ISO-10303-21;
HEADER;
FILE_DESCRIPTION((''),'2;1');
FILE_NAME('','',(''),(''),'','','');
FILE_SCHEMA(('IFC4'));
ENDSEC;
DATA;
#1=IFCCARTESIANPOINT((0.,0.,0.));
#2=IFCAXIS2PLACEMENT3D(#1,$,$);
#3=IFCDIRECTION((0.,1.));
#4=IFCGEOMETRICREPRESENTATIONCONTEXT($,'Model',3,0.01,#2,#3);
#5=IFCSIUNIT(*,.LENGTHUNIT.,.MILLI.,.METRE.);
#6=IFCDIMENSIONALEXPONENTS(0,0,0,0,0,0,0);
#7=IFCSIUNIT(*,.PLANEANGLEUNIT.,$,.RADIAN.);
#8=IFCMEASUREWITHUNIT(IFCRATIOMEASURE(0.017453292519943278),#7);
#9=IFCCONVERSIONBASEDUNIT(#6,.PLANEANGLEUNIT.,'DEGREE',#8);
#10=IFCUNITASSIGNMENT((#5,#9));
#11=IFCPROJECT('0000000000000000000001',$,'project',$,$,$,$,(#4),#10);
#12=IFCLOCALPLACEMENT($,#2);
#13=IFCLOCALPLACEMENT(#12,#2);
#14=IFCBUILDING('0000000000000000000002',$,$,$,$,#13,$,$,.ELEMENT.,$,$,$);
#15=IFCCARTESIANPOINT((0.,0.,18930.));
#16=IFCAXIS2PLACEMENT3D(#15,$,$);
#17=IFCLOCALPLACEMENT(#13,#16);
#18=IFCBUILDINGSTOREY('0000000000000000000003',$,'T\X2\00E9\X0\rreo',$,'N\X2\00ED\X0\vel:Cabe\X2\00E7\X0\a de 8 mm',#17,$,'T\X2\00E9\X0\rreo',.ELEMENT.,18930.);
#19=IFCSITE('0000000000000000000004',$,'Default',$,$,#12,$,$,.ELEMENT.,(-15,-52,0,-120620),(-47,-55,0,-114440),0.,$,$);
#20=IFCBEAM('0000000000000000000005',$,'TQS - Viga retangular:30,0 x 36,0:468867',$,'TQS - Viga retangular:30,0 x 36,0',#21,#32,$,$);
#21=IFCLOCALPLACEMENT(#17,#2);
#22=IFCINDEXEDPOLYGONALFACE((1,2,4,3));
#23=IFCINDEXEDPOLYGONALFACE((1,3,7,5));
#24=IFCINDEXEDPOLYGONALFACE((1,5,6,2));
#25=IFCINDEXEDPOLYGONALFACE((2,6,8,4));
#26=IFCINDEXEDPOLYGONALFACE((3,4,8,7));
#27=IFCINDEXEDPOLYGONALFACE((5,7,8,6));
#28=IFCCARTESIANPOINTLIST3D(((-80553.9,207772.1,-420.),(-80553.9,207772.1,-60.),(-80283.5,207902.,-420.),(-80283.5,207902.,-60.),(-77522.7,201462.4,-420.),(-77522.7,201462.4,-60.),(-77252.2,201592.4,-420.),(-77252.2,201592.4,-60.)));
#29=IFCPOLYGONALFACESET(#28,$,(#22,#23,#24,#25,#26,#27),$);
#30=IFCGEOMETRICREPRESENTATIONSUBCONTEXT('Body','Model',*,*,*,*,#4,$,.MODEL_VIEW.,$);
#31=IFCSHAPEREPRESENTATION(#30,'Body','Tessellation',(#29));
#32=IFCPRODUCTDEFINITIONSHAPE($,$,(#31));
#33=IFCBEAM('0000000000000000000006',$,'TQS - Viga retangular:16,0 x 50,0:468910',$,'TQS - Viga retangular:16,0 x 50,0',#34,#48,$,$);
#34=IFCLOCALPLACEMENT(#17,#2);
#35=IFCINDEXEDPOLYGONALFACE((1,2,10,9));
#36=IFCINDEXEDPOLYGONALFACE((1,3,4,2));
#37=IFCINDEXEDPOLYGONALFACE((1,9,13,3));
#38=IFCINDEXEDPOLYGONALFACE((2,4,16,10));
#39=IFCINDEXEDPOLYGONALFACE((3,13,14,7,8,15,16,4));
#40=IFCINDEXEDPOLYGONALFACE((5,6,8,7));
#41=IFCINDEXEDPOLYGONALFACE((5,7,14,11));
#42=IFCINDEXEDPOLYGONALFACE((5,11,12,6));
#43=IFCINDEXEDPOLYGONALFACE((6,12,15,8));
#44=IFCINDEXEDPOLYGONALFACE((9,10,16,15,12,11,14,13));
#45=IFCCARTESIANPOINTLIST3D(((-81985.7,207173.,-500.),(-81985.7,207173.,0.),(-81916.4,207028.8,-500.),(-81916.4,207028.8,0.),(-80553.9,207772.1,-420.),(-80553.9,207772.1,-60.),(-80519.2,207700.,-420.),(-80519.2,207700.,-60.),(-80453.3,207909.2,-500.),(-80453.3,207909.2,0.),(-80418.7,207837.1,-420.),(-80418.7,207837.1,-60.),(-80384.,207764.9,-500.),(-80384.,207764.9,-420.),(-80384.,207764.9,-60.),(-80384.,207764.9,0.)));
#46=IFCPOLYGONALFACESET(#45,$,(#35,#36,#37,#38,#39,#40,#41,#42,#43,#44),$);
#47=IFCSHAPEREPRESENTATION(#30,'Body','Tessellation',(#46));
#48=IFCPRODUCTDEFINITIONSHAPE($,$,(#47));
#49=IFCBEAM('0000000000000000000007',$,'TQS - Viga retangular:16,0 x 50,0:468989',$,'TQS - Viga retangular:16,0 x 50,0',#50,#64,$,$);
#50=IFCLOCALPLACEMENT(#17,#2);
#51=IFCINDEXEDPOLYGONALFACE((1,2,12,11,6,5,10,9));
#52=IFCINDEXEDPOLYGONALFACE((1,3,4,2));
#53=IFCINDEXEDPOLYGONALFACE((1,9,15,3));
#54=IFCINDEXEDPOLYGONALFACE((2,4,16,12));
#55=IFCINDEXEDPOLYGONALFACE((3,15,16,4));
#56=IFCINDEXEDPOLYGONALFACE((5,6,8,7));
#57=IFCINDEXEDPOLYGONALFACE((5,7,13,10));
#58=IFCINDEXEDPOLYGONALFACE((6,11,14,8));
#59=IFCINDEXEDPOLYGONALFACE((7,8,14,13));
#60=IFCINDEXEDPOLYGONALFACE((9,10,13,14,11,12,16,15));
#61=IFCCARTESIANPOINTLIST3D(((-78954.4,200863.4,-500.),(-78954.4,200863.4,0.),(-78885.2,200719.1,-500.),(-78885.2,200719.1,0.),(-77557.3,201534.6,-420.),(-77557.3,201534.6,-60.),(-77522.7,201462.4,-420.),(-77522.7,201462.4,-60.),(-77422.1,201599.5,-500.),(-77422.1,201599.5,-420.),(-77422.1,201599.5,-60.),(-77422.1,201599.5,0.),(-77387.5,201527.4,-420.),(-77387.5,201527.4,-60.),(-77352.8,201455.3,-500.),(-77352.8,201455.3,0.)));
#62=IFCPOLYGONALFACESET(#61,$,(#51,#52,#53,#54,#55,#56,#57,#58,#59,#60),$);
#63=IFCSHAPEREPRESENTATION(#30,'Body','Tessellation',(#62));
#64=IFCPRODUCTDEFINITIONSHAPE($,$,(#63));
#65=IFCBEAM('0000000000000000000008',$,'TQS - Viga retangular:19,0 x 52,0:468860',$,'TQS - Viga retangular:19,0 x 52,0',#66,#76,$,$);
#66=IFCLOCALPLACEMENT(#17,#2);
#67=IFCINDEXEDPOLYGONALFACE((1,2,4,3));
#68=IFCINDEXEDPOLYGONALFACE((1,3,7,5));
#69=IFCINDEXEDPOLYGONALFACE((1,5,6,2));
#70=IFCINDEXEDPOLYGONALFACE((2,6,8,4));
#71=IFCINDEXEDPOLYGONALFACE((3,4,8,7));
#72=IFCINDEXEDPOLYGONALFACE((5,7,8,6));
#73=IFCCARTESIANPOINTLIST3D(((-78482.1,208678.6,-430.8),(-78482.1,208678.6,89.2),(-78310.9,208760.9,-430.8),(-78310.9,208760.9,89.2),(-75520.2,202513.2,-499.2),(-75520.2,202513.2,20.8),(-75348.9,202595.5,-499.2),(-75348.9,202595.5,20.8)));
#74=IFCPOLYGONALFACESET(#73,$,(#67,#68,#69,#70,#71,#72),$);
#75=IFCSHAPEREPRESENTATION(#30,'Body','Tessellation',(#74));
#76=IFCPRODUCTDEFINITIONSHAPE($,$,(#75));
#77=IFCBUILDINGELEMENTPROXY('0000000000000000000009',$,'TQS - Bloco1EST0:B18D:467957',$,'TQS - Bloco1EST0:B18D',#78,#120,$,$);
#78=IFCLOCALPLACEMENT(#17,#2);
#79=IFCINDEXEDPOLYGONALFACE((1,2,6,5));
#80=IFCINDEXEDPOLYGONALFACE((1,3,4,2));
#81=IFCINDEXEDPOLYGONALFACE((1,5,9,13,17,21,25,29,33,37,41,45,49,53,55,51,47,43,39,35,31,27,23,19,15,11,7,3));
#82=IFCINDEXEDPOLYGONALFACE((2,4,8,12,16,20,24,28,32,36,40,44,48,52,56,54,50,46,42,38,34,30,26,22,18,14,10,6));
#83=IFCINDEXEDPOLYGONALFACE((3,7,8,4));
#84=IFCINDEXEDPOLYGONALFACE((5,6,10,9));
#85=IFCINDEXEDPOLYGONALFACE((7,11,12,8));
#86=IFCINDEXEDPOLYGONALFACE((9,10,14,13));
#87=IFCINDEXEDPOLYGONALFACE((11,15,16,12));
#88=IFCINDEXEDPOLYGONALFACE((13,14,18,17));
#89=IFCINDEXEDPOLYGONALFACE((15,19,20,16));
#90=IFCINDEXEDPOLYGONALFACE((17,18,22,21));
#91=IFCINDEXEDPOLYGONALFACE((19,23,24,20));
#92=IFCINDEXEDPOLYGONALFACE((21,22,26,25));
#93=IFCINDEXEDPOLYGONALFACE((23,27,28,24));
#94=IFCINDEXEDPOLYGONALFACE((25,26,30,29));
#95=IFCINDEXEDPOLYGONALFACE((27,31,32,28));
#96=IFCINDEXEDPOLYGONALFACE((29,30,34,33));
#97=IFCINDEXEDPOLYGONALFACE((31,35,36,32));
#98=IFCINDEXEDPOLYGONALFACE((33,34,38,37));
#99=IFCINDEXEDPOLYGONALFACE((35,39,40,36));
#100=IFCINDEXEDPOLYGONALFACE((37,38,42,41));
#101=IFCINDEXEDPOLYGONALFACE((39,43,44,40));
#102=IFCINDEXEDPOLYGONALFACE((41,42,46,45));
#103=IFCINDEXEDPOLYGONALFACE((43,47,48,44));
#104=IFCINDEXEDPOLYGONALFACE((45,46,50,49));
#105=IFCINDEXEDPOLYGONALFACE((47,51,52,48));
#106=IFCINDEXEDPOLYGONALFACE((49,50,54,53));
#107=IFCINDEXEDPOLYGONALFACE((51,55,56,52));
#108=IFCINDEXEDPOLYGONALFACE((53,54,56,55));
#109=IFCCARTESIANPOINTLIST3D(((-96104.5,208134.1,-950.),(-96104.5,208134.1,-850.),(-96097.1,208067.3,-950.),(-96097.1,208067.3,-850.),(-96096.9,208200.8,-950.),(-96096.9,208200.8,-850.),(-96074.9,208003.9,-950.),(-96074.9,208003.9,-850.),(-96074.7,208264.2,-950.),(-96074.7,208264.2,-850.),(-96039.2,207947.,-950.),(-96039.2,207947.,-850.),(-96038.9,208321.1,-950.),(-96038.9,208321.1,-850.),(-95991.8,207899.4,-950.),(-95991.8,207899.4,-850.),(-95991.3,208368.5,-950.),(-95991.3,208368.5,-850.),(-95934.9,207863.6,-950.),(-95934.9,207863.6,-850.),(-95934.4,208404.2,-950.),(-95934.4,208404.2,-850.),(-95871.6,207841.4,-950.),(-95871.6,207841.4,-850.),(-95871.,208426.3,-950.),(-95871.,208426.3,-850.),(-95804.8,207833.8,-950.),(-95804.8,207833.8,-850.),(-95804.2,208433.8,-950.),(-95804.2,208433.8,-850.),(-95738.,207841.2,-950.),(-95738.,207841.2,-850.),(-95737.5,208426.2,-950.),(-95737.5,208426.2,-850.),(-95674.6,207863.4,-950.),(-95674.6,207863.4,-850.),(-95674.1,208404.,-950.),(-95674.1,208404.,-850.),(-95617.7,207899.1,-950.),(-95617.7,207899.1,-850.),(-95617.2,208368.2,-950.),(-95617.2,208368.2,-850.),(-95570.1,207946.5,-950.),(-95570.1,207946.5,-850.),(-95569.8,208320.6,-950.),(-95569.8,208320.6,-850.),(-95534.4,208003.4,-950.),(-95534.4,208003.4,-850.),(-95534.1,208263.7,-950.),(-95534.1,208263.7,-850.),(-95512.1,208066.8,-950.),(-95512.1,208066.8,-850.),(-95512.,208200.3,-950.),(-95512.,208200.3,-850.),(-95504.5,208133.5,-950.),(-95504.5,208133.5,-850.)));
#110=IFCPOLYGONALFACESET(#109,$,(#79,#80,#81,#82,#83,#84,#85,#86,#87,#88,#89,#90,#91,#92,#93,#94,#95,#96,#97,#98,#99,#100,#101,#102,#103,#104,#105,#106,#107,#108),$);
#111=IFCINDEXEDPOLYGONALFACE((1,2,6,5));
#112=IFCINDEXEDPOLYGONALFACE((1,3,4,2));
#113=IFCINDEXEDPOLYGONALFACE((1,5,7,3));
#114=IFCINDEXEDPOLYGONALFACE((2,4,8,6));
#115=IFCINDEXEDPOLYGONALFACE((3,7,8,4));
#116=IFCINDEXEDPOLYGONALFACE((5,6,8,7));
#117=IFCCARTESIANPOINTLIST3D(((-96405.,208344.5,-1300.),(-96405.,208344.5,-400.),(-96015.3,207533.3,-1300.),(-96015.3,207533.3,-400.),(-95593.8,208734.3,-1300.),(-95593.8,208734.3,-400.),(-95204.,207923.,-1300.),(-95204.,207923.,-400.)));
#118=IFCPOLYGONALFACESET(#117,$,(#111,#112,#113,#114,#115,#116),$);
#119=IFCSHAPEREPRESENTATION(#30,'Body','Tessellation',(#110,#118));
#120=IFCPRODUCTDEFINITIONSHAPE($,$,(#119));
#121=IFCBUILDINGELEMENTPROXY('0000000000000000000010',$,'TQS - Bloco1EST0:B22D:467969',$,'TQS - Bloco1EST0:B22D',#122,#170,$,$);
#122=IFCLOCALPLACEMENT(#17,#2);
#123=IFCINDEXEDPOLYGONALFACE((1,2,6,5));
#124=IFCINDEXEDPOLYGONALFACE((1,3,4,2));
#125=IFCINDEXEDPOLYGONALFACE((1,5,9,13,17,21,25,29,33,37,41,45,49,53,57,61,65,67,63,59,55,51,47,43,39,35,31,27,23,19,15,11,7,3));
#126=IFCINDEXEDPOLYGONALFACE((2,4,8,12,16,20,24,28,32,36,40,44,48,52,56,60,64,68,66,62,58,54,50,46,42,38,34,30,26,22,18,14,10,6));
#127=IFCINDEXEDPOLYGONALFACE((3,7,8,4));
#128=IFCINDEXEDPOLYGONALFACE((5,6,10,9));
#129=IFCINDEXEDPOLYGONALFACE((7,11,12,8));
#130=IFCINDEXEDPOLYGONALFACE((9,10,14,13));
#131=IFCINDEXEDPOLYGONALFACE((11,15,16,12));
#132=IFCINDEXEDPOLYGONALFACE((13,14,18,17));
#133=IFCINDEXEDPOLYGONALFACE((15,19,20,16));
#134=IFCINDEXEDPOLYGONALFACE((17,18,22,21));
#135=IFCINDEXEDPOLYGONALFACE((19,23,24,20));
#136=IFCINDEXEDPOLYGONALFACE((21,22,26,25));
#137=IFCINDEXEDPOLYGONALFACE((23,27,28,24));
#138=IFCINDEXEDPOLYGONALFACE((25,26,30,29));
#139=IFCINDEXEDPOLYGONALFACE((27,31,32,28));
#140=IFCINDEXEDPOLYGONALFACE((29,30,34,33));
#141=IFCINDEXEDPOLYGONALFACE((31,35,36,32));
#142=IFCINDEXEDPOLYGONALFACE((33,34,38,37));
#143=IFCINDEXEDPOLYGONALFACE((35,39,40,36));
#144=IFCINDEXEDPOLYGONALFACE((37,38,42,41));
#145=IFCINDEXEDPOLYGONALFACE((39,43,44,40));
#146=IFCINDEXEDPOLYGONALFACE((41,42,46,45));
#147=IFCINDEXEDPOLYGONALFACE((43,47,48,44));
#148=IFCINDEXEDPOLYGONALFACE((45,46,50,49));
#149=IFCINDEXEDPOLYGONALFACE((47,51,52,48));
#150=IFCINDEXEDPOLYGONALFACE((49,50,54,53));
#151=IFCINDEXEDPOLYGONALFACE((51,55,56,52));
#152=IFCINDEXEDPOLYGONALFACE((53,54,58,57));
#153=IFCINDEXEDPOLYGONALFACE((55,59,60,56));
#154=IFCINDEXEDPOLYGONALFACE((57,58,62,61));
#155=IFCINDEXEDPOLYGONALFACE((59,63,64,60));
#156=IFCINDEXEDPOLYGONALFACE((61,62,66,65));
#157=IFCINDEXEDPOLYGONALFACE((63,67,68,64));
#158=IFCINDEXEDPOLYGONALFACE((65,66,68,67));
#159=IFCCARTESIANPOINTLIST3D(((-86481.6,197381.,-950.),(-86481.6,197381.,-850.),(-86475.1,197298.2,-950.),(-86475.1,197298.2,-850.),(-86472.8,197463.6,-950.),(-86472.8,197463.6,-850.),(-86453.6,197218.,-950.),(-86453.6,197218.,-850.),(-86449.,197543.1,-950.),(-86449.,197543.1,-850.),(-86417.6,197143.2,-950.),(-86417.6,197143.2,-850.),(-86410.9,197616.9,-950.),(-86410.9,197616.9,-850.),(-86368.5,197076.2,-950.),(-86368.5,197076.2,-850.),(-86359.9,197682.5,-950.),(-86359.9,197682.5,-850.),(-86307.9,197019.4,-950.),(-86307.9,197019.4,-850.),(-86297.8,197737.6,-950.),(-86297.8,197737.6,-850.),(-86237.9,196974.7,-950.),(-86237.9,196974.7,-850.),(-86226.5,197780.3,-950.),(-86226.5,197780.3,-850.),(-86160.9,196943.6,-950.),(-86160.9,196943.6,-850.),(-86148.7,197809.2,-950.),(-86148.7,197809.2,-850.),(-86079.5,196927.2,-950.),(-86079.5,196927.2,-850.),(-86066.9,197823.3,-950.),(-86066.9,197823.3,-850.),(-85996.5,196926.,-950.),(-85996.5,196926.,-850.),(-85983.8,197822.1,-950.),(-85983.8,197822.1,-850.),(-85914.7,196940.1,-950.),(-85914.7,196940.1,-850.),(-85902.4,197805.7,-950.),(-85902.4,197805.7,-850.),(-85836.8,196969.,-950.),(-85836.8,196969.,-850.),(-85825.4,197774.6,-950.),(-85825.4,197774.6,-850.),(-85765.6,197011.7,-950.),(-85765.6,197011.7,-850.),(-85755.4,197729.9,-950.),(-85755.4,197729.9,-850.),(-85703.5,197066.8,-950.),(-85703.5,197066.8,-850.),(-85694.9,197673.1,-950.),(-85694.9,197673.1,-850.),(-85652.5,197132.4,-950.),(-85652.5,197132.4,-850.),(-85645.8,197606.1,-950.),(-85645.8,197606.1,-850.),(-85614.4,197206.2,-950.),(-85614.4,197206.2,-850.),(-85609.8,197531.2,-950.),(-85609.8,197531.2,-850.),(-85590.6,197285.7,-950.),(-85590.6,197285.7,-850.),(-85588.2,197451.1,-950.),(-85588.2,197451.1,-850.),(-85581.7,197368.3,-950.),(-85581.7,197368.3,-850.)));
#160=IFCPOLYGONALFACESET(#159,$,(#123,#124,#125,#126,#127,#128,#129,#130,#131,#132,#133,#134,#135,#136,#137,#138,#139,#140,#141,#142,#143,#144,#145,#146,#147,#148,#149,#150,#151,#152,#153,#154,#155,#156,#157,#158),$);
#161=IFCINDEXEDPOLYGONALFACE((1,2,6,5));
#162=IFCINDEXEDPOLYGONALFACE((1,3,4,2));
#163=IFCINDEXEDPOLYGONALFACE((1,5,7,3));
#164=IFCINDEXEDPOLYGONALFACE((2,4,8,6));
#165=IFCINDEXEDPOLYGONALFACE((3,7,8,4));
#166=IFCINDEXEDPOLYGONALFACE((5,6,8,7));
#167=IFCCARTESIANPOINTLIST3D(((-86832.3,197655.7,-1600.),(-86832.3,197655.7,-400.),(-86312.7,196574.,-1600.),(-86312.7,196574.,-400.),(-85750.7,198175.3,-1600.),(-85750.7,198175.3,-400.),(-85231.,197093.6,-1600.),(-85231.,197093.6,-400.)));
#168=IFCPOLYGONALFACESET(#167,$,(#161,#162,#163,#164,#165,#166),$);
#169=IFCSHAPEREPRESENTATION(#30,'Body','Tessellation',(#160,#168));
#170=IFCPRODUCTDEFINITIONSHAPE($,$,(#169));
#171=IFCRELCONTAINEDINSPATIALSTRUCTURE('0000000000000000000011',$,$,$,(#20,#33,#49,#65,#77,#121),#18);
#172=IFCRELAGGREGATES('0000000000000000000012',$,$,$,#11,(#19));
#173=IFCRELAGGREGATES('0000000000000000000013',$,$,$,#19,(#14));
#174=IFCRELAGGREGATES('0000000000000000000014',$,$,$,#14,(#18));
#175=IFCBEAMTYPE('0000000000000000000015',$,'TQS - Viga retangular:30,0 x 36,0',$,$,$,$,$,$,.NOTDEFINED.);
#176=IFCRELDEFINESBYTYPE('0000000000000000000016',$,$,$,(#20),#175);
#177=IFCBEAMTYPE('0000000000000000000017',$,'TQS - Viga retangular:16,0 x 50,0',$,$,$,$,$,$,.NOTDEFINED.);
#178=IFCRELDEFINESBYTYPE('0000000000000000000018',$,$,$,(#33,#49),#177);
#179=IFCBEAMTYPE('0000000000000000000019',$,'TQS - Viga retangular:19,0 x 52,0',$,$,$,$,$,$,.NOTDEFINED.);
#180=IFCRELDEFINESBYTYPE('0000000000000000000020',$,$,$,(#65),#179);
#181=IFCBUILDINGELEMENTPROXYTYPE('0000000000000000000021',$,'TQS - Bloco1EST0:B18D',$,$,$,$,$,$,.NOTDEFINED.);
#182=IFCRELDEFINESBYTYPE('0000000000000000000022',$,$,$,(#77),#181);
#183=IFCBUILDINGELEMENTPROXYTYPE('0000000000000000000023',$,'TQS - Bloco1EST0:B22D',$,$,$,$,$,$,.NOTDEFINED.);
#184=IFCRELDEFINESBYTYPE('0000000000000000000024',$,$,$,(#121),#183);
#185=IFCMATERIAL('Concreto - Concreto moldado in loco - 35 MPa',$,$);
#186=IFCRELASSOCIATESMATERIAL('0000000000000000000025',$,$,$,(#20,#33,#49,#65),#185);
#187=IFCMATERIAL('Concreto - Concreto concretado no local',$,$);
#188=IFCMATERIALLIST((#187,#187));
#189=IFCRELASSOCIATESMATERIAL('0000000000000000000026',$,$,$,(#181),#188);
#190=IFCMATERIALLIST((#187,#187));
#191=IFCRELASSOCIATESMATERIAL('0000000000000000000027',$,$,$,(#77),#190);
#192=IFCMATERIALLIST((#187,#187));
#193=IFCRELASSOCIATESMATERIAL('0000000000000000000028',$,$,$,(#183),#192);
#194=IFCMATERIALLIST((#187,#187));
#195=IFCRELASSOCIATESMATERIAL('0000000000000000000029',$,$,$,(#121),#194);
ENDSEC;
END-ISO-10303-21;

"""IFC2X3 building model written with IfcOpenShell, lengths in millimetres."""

from ifc_helpers import new_model, entity, si_unit, converted_unit, direction, frame, frame_2d, origin, origin_2d_with_axis, place, context, subcontext, project, spatial, polyline, rectangle, circle, extrude, boolean, clip, halfspace, bounded_halfspace, source, transform, mapped, material, material_list, type_object, type_shapes, element, save


model = new_model("IFC2X3")

# Units and contexts
model_context = context("Model", 3, precision=0.01, world=origin(), true_north=direction((0.0, 1.0)))
body_context = subcontext(model_context, "Body", "Model", "MODEL_VIEW")
ifc_project = project(units=[si_unit("LENGTHUNIT", "METRE", prefix="MILLI"), converted_unit("PLANEANGLEUNIT", "DEGREE", entity("IfcRatioMeasure", 0.017453292519943278), si_unit("PLANEANGLEUNIT", "RADIAN"), dimensions=[0, 0, 0, 0, 0, 0, 0])], contexts=[model_context])

# Site, building, storey
site_placement = place(None, origin())
site = spatial("IfcSite", under=ifc_project, at=site_placement, Name="Default", CompositionType="ELEMENT", RefLatitude=(-15, -52, 0, -120620), RefLongitude=(-47, -55, 0, -114440), RefElevation=0.0)
building_placement = place(site_placement, origin())
building = spatial("IfcBuilding", under=site, at=building_placement, CompositionType="ELEMENT")
storey_placement = place(building_placement, frame((0.0, 0.0, 18930.0)))
storey = spatial("IfcBuildingStorey", under=building, at=storey_placement, Name="Térreo", ObjectType="Nível:Cabeça de 8 mm", LongName="Térreo", CompositionType="ELEMENT", Elevation=18930.0)

# Beams
ifc_material_1 = material(Name="Concreto - Concreto moldado in loco - 35 MPa")
beam_type_1 = type_object("IfcBeamType", Name="TQS - Viga retangular:30,0 x 36,0", PredefinedType="NOTDEFINED")
beam_1_placement = place(storey_placement, frame((-77387.5, 201527.4, -60.0), z_axis=(0.0, 0.0, 1.0), x_axis=(-0.43303, 0.90138, 0.0)))
element("IfcBeam", 1, at=beam_1_placement, inside=storey, type_object=beam_type_1, material=ifc_material_1, Name="TQS - Viga retangular:30,0 x 36,0:468867", ObjectType="TQS - Viga retangular:30,0 x 36,0", context=body_context, shape_type="SweptSolid", body=[
    extrude(rectangle(XDim=360.0, YDim=300.0, at=frame_2d((0.0, 0.0), x_axis=(1.0, 0.0))), frame((0.0, 0.0, -180.0), z_axis=(1.0, 0.0, 0.0), x_axis=(0.0, 0.0, -1.0)), (0.0, 0.0, 1.0), 7000.0),
])
beam_type_2 = type_object("IfcBeamType", Name="TQS - Viga retangular:16,0 x 50,0", PredefinedType="NOTDEFINED")
beam_2_placement = place(storey_placement, frame((-80418.7, 207837.1, 0.0), z_axis=(0.0, 0.0, 1.0), x_axis=(-0.90138, -0.43303, 0.0)))
element("IfcBeam", 2, at=beam_2_placement, inside=storey, type_object=beam_type_2, material=ifc_material_1, Name="TQS - Viga retangular:16,0 x 50,0:468910", ObjectType="TQS - Viga retangular:16,0 x 50,0", context=body_context, shape_type="SweptSolid", body=[
    boolean("DIFFERENCE", clip(extrude(rectangle(XDim=500.0, YDim=160.0, at=frame_2d((0.0, 0.0), x_axis=(1.0, 0.0))), frame((0.0, 0.0, -250.0), z_axis=(1.0, 0.0, 0.0), x_axis=(0.0, 0.0, -1.0)), (0.0, 0.0, 1.0), 1700.0), bounded_halfspace(frame((150.0, 0.0, -420.0), z_axis=(-1.0, 0.0, 0.0), x_axis=(0.0, 1.0, 0.0)), False, frame((0.0, 0.0, -250.0), z_axis=(1.0, 0.0, 0.0), x_axis=(0.0, 0.0, -1.0)), polyline([(170.0, 0.0), (-190.0, 0.0), (-190.0, 80.0), (-90.0, 80.0), (170.0, 80.0), (170.0, 0.0)]))), extrude(rectangle(XDim=360.0, YDim=80.0, at=frame_2d((0.0, 0.0), x_axis=(0.0, 1.0))), frame((0.0, 40.0, -240.0), z_axis=(-1.0, 0.0, 0.0), x_axis=(0.0, -1.0, 0.0)), (0.0, 0.0, -1.0), 150.0)),
])
beam_3_placement = place(storey_placement, frame((-77387.5, 201527.4, 0.0), z_axis=(0.0, 0.0, 1.0), x_axis=(-0.90138, -0.43303, 0.0)))
element("IfcBeam", 3, at=beam_3_placement, inside=storey, type_object=beam_type_2, material=ifc_material_1, Name="TQS - Viga retangular:16,0 x 50,0:468989", ObjectType="TQS - Viga retangular:16,0 x 50,0", context=body_context, shape_type="SweptSolid", body=[
    boolean("DIFFERENCE", clip(extrude(rectangle(XDim=500.0, YDim=160.0, at=frame_2d((0.0, 0.0), x_axis=(0.0, 1.0))), frame((0.0, 0.0, -250.0), z_axis=(1.0, 0.0, 0.0), x_axis=(0.0, 1.0, 0.0)), (0.0, 0.0, 1.0), 1700.0), bounded_halfspace(frame((150.0, -7000.0, -420.0), z_axis=(-1.0, 0.0, 0.0), x_axis=(0.0, 1.0, 0.0)), False, frame((0.0, 0.0, -250.0), z_axis=(1.0, 0.0, 0.0), x_axis=(0.0, 1.0, 0.0)), polyline([(0.0, 190.0), (0.0, -170.0), (-80.0, -170.0), (-80.0, 90.0), (-80.0, 190.0), (0.0, 190.0)]))), extrude(rectangle(XDim=360.0, YDim=80.0, at=frame_2d((0.0, 0.0), x_axis=(0.0, 1.0))), frame((150.0, -40.0, -240.0), z_axis=(1.0, 0.0, 0.0), x_axis=(0.0, 1.0, 0.0)), (0.0, 0.0, -1.0), 150.0)),
])
beam_type_3 = type_object("IfcBeamType", Name="TQS - Viga retangular:19,0 x 52,0", PredefinedType="NOTDEFINED")
beam_4_placement = place(storey_placement, frame((-75399.9, 202482.2, 20.0), z_axis=(0.00433, -0.009013, 0.99995), x_axis=(-0.433008, 0.901334, 0.01)))
element("IfcBeam", 4, at=beam_4_placement, inside=storey, type_object=beam_type_3, material=ifc_material_1, Name="TQS - Viga retangular:19,0 x 52,0:468860", ObjectType="TQS - Viga retangular:19,0 x 52,0", context=body_context, shape_type="SweptSolid", body=[
    clip(clip(extrude(rectangle(XDim=520.0, YDim=190.0, at=frame_2d((0.0, 0.0), x_axis=(1.0, 0.0))), frame((74.8, 0.0, -260.0), z_axis=(1.0, 0.0, 0.0), x_axis=(0.0, 0.0, -1.0)), (0.0, 0.0, 1.0), 6845.5), halfspace(frame((6919.5, 305.0, -89.2), z_axis=(0.99995, 0.0, -0.01), x_axis=(-0.01, 0.0, -0.99995)), False)), halfspace(frame((79.8, -95.0, -20.8), z_axis=(-0.99995, 0.0, 0.01), x_axis=(-0.01, 0.0, -0.99995)), False)),
])

# Building element proxies
ifc_material_2 = material(Name="Concreto - Concreto concretado no local")
ifc_material_list_1 = material_list([ifc_material_2, ifc_material_2])
ifc_material_list_2 = material_list([ifc_material_2, ifc_material_2])
building_element_proxy_type_1 = type_object("IfcBuildingElementProxyType", Name="TQS - Bloco1EST0:B18D", PredefinedType="NOTDEFINED", material=ifc_material_list_2)
shared_shape_1 = source(origin(), body_context, "Body", "SweptSolid", [
    extrude(circle(Radius=300.0, at=frame_2d((0.0, 0.0), x_axis=(1.0, 0.0))), frame((0.0, 0.0, -550.0)), (0.0, 0.0, 1.0), 100.0),
    extrude(rectangle(XDim=900.0, YDim=900.0, at=origin_2d_with_axis()), frame((0.0, 0.0, -900.0), z_axis=(0.0, 0.0, 1.0), x_axis=(-1.0, 0.0, 0.0)), (0.0, 0.0, 1.0), 900.0),
])
type_shapes(building_element_proxy_type_1, [shared_shape_1])
proxy_1_placement = place(storey_placement, frame((-95804.5, 208133.8, -400.0), z_axis=(0.0, 0.0, 1.0), x_axis=(-0.43303, 0.90138, 0.0)))
element("IfcBuildingElementProxy", 5, at=proxy_1_placement, inside=storey, type_object=building_element_proxy_type_1, material=ifc_material_list_1, Name="TQS - Bloco1EST0:B18D:467957", ObjectType="TQS - Bloco1EST0:B18D", context=body_context, shape_type="MappedRepresentation", body=[
    mapped(shared_shape_1, transform((0.0, 0.0, 0.0), scale=1.0)),
])
ifc_material_list_3 = material_list([ifc_material_2, ifc_material_2])
ifc_material_list_4 = material_list([ifc_material_2, ifc_material_2])
building_element_proxy_type_2 = type_object("IfcBuildingElementProxyType", Name="TQS - Bloco1EST0:B22D", PredefinedType="NOTDEFINED", material=ifc_material_list_4)
shared_shape_2 = source(origin(), body_context, "Body", "SweptSolid", [
    extrude(circle(Radius=450.0, at=frame_2d((0.0, 0.0), x_axis=(1.0, 0.0))), frame((0.0, 0.0, -550.0)), (0.0, 0.0, 1.0), 100.0),
    extrude(rectangle(XDim=1200.0, YDim=1200.0, at=origin_2d_with_axis()), frame((0.0, 0.0, -1200.0), z_axis=(0.0, 0.0, 1.0), x_axis=(-1.0, 0.0, 0.0)), (0.0, 0.0, 1.0), 1200.0),
])
type_shapes(building_element_proxy_type_2, [shared_shape_2])
proxy_2_placement = place(storey_placement, frame((-86031.7, 197374.6, -400.0), z_axis=(0.0, 0.0, 1.0), x_axis=(-0.43303, 0.90138, 0.0)))
element("IfcBuildingElementProxy", 6, at=proxy_2_placement, inside=storey, type_object=building_element_proxy_type_2, material=ifc_material_list_3, Name="TQS - Bloco1EST0:B22D:467969", ObjectType="TQS - Bloco1EST0:B22D", context=body_context, shape_type="MappedRepresentation", body=[
    mapped(shared_shape_2, transform((0.0, 0.0, 0.0), scale=1.0)),
])

save(model, "model.ifc")
